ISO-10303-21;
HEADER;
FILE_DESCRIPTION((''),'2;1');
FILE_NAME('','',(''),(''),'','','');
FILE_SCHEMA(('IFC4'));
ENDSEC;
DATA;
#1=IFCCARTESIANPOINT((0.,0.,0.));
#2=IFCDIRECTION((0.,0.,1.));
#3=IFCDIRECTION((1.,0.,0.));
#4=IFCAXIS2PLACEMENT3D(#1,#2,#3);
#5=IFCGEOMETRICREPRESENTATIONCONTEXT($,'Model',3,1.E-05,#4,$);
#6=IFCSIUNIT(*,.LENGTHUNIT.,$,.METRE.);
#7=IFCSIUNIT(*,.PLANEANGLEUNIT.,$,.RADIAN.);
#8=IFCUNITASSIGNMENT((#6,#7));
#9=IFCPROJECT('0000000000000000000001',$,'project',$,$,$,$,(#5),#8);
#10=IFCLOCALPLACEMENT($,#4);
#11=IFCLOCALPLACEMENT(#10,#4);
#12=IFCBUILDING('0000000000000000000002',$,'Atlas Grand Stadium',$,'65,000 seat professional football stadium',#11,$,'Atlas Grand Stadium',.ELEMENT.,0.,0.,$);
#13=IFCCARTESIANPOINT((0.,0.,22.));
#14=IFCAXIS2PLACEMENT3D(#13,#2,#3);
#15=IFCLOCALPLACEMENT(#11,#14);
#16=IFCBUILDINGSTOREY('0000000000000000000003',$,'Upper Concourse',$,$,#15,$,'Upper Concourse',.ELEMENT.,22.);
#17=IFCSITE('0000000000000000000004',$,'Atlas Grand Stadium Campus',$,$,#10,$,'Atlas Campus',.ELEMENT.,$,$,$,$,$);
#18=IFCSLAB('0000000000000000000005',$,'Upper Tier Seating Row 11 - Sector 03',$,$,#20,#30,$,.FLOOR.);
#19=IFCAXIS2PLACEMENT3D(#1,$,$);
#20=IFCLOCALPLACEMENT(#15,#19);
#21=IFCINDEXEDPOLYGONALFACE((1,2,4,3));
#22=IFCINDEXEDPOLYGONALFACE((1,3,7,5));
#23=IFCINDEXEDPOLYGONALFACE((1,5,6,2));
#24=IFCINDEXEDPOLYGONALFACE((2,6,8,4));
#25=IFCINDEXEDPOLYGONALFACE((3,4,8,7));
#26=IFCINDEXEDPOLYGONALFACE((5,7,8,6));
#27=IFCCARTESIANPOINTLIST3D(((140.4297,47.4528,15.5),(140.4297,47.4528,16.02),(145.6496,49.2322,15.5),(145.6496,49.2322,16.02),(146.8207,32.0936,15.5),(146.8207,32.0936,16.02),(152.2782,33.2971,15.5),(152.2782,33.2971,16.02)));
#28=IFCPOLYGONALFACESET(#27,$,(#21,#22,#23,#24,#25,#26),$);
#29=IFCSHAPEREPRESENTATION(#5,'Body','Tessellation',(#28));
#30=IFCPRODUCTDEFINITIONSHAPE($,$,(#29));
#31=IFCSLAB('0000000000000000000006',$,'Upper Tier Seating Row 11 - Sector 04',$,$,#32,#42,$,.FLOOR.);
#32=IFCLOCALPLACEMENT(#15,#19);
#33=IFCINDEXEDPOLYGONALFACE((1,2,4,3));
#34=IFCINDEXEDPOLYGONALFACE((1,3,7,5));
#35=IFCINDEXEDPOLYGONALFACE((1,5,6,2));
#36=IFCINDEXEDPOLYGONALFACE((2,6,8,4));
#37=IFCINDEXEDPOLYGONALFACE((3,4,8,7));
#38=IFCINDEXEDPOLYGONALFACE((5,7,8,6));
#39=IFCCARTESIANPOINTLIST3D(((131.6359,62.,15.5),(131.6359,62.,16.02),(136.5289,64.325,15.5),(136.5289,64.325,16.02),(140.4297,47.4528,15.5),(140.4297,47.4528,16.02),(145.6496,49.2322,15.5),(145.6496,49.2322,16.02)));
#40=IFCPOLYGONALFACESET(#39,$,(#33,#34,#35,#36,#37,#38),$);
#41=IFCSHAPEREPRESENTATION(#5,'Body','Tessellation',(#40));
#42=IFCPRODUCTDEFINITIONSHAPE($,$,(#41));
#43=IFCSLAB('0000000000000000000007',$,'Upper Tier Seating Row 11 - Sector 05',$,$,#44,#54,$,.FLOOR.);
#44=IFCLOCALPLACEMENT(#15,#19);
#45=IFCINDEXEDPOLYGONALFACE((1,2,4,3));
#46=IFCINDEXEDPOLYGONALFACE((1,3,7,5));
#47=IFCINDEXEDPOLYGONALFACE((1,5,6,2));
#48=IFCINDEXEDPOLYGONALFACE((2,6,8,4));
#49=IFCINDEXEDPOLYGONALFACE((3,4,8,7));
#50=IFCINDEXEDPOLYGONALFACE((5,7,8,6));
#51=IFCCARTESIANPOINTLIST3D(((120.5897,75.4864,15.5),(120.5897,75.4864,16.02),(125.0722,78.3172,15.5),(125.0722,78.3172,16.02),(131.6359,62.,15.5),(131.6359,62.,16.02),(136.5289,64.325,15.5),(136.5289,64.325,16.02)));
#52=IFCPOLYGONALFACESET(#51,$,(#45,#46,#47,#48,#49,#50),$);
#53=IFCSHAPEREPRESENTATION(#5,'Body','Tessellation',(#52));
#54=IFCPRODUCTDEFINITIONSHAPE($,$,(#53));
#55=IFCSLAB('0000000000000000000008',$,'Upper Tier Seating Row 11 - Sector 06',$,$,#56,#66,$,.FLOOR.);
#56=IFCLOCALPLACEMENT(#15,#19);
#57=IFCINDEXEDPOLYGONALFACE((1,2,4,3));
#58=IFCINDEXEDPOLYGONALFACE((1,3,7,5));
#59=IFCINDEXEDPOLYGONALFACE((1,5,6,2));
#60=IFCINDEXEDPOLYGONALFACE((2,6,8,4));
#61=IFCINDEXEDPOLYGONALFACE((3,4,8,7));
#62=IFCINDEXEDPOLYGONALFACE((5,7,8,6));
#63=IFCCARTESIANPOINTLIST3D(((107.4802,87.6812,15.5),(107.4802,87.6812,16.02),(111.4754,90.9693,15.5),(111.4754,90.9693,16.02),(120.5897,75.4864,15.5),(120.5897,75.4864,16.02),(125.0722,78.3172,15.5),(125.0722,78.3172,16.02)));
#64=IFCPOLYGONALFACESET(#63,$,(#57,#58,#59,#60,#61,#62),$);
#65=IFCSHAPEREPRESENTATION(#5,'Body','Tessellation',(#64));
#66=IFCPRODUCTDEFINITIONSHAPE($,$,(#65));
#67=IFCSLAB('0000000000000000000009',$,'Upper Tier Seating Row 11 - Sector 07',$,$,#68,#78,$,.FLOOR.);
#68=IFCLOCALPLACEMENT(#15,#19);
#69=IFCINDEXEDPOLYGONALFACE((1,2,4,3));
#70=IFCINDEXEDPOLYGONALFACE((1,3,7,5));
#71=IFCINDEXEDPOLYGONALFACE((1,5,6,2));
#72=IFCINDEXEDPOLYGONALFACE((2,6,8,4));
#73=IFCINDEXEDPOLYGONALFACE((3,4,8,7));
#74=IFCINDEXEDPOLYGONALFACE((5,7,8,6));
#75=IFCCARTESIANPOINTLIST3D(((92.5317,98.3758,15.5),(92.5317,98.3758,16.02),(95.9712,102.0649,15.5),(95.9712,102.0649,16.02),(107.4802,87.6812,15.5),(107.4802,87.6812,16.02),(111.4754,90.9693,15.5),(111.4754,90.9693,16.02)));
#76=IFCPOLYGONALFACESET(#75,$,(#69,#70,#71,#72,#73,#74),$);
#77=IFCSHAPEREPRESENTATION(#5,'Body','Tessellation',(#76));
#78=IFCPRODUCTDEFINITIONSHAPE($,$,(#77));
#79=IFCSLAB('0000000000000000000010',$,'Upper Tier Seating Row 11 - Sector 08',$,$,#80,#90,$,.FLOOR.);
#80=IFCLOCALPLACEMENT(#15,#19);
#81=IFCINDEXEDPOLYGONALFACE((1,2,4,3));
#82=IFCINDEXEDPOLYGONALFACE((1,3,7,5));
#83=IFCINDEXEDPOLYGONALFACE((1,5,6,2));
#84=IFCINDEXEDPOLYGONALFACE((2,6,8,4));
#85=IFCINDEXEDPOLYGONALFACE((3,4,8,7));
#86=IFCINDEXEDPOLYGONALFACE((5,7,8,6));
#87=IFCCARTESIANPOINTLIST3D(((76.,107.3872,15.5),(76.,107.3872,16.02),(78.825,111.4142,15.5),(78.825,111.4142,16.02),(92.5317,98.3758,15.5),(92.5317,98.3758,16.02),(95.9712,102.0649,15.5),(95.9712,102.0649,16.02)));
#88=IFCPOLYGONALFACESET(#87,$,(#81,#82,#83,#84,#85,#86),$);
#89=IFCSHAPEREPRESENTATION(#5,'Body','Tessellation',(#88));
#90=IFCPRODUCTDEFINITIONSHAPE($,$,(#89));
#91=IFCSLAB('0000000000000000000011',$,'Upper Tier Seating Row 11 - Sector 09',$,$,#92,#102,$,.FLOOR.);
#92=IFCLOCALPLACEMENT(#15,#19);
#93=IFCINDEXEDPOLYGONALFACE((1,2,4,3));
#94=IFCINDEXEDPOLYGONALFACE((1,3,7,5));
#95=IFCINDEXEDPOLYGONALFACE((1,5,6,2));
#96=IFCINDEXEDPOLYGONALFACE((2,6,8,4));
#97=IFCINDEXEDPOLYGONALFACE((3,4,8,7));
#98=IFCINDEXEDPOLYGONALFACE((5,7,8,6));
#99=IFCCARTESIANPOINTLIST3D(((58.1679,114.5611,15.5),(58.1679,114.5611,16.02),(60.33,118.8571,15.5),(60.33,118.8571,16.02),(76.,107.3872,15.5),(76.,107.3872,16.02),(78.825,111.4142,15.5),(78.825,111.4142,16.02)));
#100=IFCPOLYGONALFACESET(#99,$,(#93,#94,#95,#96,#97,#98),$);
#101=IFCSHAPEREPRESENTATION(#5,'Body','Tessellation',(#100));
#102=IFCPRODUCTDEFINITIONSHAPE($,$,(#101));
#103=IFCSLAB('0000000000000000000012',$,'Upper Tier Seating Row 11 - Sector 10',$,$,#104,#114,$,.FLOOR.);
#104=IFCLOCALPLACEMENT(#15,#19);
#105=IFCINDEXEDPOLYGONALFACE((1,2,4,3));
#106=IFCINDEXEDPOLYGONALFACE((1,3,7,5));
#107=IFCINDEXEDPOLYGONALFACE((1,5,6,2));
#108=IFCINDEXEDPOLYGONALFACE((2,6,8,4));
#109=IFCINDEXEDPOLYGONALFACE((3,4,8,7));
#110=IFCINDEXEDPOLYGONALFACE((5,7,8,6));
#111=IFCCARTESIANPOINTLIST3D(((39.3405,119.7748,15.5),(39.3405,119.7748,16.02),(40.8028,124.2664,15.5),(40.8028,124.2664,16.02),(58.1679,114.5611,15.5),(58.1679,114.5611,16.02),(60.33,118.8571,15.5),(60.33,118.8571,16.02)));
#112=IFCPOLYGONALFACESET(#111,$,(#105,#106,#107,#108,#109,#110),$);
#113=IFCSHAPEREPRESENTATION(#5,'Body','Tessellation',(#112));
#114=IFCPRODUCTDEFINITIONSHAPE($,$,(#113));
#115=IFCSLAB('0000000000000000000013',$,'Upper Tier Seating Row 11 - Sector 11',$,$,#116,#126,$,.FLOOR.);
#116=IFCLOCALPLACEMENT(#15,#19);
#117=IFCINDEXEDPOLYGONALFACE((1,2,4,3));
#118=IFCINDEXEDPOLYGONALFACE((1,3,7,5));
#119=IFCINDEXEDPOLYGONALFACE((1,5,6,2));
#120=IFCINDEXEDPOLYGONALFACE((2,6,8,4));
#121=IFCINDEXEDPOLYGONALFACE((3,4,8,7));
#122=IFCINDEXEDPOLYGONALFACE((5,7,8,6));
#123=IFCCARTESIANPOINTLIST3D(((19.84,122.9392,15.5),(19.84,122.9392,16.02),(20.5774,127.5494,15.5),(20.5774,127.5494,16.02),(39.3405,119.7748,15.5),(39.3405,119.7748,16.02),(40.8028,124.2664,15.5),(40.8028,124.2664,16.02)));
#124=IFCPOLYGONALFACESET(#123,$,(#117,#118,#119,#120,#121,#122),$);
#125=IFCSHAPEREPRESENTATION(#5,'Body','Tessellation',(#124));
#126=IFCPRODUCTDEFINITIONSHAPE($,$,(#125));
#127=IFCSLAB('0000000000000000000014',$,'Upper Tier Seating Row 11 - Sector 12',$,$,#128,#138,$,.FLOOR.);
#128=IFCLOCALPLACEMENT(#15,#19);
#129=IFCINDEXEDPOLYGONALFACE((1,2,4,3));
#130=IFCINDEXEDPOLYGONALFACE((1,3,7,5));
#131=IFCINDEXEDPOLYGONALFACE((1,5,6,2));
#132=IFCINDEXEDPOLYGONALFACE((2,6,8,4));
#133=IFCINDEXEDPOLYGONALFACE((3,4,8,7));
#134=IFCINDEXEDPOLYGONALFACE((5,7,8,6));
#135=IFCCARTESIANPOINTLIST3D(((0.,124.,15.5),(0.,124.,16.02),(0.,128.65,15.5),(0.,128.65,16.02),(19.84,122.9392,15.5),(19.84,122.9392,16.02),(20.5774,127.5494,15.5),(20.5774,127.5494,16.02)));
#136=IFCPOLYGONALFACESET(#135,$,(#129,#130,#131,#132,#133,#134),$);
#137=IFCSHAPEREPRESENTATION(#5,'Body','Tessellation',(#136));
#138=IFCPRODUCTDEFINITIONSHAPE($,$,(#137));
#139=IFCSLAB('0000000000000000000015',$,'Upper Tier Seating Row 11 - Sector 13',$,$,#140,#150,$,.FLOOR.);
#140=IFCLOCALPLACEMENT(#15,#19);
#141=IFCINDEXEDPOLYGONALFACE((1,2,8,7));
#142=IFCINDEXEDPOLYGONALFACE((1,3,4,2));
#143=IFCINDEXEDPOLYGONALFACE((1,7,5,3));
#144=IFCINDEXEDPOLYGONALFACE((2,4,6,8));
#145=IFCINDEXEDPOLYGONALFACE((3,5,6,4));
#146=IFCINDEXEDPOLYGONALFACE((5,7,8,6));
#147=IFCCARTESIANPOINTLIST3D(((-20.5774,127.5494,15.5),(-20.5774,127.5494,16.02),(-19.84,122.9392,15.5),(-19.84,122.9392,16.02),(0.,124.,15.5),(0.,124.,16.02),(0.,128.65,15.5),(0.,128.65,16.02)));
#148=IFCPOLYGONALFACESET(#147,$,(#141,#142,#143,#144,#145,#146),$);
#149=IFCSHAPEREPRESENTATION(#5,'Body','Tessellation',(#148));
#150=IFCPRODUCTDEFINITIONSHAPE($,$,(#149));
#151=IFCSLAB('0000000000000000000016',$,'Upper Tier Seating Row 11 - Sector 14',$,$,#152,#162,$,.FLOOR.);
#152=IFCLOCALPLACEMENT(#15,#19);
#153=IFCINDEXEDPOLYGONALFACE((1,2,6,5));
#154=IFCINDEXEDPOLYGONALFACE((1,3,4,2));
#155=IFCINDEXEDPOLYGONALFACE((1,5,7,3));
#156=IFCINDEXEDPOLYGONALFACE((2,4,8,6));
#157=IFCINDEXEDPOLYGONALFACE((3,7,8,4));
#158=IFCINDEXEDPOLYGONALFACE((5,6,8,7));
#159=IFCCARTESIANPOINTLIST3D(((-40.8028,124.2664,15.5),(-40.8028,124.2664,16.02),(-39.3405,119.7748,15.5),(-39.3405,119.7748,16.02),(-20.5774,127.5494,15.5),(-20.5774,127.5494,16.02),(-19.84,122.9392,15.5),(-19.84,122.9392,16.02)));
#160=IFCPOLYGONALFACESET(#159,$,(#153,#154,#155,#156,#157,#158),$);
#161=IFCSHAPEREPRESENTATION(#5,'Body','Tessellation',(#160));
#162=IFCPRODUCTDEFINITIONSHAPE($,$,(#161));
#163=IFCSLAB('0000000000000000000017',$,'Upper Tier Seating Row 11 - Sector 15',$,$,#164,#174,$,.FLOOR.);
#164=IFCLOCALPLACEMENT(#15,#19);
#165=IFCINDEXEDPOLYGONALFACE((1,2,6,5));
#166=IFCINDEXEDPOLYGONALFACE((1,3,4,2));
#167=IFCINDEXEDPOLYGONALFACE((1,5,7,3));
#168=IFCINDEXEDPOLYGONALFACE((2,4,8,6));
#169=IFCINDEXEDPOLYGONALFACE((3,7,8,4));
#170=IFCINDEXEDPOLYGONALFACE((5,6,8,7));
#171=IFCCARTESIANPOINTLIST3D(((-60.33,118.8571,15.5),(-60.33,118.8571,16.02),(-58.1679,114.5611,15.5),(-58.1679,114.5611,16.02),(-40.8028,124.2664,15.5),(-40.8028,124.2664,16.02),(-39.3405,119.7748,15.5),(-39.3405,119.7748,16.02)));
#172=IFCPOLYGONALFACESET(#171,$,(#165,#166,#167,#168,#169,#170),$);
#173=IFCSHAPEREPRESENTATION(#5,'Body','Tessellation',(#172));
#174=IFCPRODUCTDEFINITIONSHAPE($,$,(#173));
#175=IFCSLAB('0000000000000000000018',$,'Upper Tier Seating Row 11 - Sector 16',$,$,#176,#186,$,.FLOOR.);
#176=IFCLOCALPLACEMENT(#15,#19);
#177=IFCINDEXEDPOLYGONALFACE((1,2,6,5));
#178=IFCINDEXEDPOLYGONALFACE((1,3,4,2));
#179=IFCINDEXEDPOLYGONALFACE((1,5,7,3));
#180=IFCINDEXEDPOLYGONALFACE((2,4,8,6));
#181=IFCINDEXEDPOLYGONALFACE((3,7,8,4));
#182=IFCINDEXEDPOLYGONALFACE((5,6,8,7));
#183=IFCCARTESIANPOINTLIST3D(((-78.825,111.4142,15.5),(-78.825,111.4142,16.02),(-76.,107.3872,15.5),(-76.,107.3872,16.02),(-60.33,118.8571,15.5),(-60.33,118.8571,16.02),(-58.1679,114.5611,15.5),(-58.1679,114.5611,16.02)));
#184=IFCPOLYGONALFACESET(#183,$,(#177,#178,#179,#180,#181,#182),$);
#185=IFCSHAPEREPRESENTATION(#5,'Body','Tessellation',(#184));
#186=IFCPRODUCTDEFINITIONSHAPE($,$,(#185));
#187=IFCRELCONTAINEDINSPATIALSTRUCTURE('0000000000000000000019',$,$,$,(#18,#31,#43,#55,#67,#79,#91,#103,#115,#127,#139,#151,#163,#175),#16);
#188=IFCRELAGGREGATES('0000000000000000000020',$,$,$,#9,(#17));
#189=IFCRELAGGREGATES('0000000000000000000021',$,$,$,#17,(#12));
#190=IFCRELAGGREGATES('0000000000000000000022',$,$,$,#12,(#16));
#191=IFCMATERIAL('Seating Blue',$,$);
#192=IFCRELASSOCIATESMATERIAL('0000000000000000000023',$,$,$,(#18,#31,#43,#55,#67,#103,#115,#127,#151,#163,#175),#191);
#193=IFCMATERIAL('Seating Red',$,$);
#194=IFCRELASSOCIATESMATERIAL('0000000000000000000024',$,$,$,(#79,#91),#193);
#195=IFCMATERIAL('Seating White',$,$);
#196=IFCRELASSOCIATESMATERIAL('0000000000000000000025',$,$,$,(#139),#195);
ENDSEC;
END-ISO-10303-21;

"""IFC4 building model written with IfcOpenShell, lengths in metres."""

from ifc_helpers import new_model, si_unit, frame, origin_with_axes, place, context, project, spatial, polyline, outline, extrude, material, element, save


model = new_model("IFC4")

# Units and contexts
model_context = context("Model", 3, precision=1e-05, world=origin_with_axes())
ifc_project = project(units=[si_unit("LENGTHUNIT", "METRE"), si_unit("PLANEANGLEUNIT", "RADIAN")], contexts=[model_context])

# Site, building, storey
site_placement = place(None, origin_with_axes())
site = spatial("IfcSite", under=ifc_project, at=site_placement, Name="Atlas Grand Stadium Campus", LongName="Atlas Campus", CompositionType="ELEMENT")
building_placement = place(site_placement, origin_with_axes())
building = spatial("IfcBuilding", under=site, at=building_placement, Name="Atlas Grand Stadium", ObjectType="65,000 seat professional football stadium", LongName="Atlas Grand Stadium", CompositionType="ELEMENT", ElevationOfRefHeight=0.0, ElevationOfTerrain=0.0)
storey_placement = place(building_placement, frame((0.0, 0.0, 22.0), z_axis=(0.0, 0.0, 1.0), x_axis=(1.0, 0.0, 0.0)))
storey = spatial("IfcBuildingStorey", under=building, at=storey_placement, Name="Upper Concourse", LongName="Upper Concourse", CompositionType="ELEMENT", Elevation=22.0)

# Slabs
ifc_material_1 = material(Name="Seating Blue")
slab_1_placement = place(storey_placement, frame((0.0, 0.0, 15.5), z_axis=(0.0, 0.0, 1.0), x_axis=(1.0, 0.0, 0.0)))
element("IfcSlab", 1, at=slab_1_placement, inside=storey, material=ifc_material_1, Name="Upper Tier Seating Row 11 - Sector 03", PredefinedType="FLOOR", context=model_context, shape_type="SweptSolid", body=[
    extrude(outline(polyline([(152.2782, 33.2971), (145.6496, 49.2322), (140.4297, 47.4528), (146.8207, 32.0936), (152.2782, 33.2971)])), origin_with_axes(), (0.0, 0.0, 1.0), 0.52),
])
slab_2_placement = place(storey_placement, frame((0.0, 0.0, 15.5), z_axis=(0.0, 0.0, 1.0), x_axis=(1.0, 0.0, 0.0)))
element("IfcSlab", 2, at=slab_2_placement, inside=storey, material=ifc_material_1, Name="Upper Tier Seating Row 11 - Sector 04", PredefinedType="FLOOR", context=model_context, shape_type="SweptSolid", body=[
    extrude(outline(polyline([(145.6496, 49.2322), (136.5289, 64.325), (131.6359, 62.0), (140.4297, 47.4528), (145.6496, 49.2322)])), origin_with_axes(), (0.0, 0.0, 1.0), 0.52),
])
slab_3_placement = place(storey_placement, frame((0.0, 0.0, 15.5), z_axis=(0.0, 0.0, 1.0), x_axis=(1.0, 0.0, 0.0)))
element("IfcSlab", 3, at=slab_3_placement, inside=storey, material=ifc_material_1, Name="Upper Tier Seating Row 11 - Sector 05", PredefinedType="FLOOR", context=model_context, shape_type="SweptSolid", body=[
    extrude(outline(polyline([(136.5289, 64.325), (125.0721, 78.3172), (120.5897, 75.4864), (131.6359, 62.0), (136.5289, 64.325)])), origin_with_axes(), (0.0, 0.0, 1.0), 0.52),
])
slab_4_placement = place(storey_placement, frame((0.0, 0.0, 15.5), z_axis=(0.0, 0.0, 1.0), x_axis=(1.0, 0.0, 0.0)))
element("IfcSlab", 4, at=slab_4_placement, inside=storey, material=ifc_material_1, Name="Upper Tier Seating Row 11 - Sector 06", PredefinedType="FLOOR", context=model_context, shape_type="SweptSolid", body=[
    extrude(outline(polyline([(125.0721, 78.3172), (111.4754, 90.9693), (107.4802, 87.6812), (120.5897, 75.4864), (125.0721, 78.3172)])), origin_with_axes(), (0.0, 0.0, 1.0), 0.52),
])
slab_5_placement = place(storey_placement, frame((0.0, 0.0, 15.5), z_axis=(0.0, 0.0, 1.0), x_axis=(1.0, 0.0, 0.0)))
element("IfcSlab", 5, at=slab_5_placement, inside=storey, material=ifc_material_1, Name="Upper Tier Seating Row 11 - Sector 07", PredefinedType="FLOOR", context=model_context, shape_type="SweptSolid", body=[
    extrude(outline(polyline([(111.4754, 90.9693), (95.9712, 102.0649), (92.5317, 98.3758), (107.4802, 87.6812), (111.4754, 90.9693)])), origin_with_axes(), (0.0, 0.0, 1.0), 0.52),
])
ifc_material_2 = material(Name="Seating Red")
slab_6_placement = place(storey_placement, frame((0.0, 0.0, 15.5), z_axis=(0.0, 0.0, 1.0), x_axis=(1.0, 0.0, 0.0)))
element("IfcSlab", 6, at=slab_6_placement, inside=storey, material=ifc_material_2, Name="Upper Tier Seating Row 11 - Sector 08", PredefinedType="FLOOR", context=model_context, shape_type="SweptSolid", body=[
    extrude(outline(polyline([(95.9712, 102.0649), (78.825, 111.4142), (76.0, 107.3872), (92.5317, 98.3758), (95.9712, 102.0649)])), origin_with_axes(), (0.0, 0.0, 1.0), 0.52),
])
slab_7_placement = place(storey_placement, frame((0.0, 0.0, 15.5), z_axis=(0.0, 0.0, 1.0), x_axis=(1.0, 0.0, 0.0)))
element("IfcSlab", 7, at=slab_7_placement, inside=storey, material=ifc_material_2, Name="Upper Tier Seating Row 11 - Sector 09", PredefinedType="FLOOR", context=model_context, shape_type="SweptSolid", body=[
    extrude(outline(polyline([(78.825, 111.4142), (60.33, 118.8571), (58.1679, 114.5611), (76.0, 107.3872), (78.825, 111.4142)])), origin_with_axes(), (0.0, 0.0, 1.0), 0.52),
])
slab_8_placement = place(storey_placement, frame((0.0, 0.0, 15.5), z_axis=(0.0, 0.0, 1.0), x_axis=(1.0, 0.0, 0.0)))
element("IfcSlab", 8, at=slab_8_placement, inside=storey, material=ifc_material_1, Name="Upper Tier Seating Row 11 - Sector 10", PredefinedType="FLOOR", context=model_context, shape_type="SweptSolid", body=[
    extrude(outline(polyline([(60.33, 118.8571), (40.8028, 124.2664), (39.3405, 119.7748), (58.1679, 114.5611), (60.33, 118.8571)])), origin_with_axes(), (0.0, 0.0, 1.0), 0.52),
])
slab_9_placement = place(storey_placement, frame((0.0, 0.0, 15.5), z_axis=(0.0, 0.0, 1.0), x_axis=(1.0, 0.0, 0.0)))
element("IfcSlab", 9, at=slab_9_placement, inside=storey, material=ifc_material_1, Name="Upper Tier Seating Row 11 - Sector 11", PredefinedType="FLOOR", context=model_context, shape_type="SweptSolid", body=[
    extrude(outline(polyline([(40.8028, 124.2664), (20.5774, 127.5494), (19.84, 122.9392), (39.3405, 119.7748), (40.8028, 124.2664)])), origin_with_axes(), (0.0, 0.0, 1.0), 0.52),
])
slab_10_placement = place(storey_placement, frame((0.0, 0.0, 15.5), z_axis=(0.0, 0.0, 1.0), x_axis=(1.0, 0.0, 0.0)))
element("IfcSlab", 10, at=slab_10_placement, inside=storey, material=ifc_material_1, Name="Upper Tier Seating Row 11 - Sector 12", PredefinedType="FLOOR", context=model_context, shape_type="SweptSolid", body=[
    extrude(outline(polyline([(20.5774, 127.5494), (0.0, 128.65), (0.0, 124.0), (19.84, 122.9392), (20.5774, 127.5494)])), origin_with_axes(), (0.0, 0.0, 1.0), 0.52),
])
ifc_material_3 = material(Name="Seating White")
slab_11_placement = place(storey_placement, frame((0.0, 0.0, 15.5), z_axis=(0.0, 0.0, 1.0), x_axis=(1.0, 0.0, 0.0)))
element("IfcSlab", 11, at=slab_11_placement, inside=storey, material=ifc_material_3, Name="Upper Tier Seating Row 11 - Sector 13", PredefinedType="FLOOR", context=model_context, shape_type="SweptSolid", body=[
    extrude(outline(polyline([(0.0, 128.65), (-20.5774, 127.5494), (-19.84, 122.9392), (0.0, 124.0), (0.0, 128.65)])), origin_with_axes(), (0.0, 0.0, 1.0), 0.52),
])
slab_12_placement = place(storey_placement, frame((0.0, 0.0, 15.5), z_axis=(0.0, 0.0, 1.0), x_axis=(1.0, 0.0, 0.0)))
element("IfcSlab", 12, at=slab_12_placement, inside=storey, material=ifc_material_1, Name="Upper Tier Seating Row 11 - Sector 14", PredefinedType="FLOOR", context=model_context, shape_type="SweptSolid", body=[
    extrude(outline(polyline([(-20.5774, 127.5494), (-40.8028, 124.2664), (-39.3405, 119.7748), (-19.84, 122.9392), (-20.5774, 127.5494)])), origin_with_axes(), (0.0, 0.0, 1.0), 0.52),
])
slab_13_placement = place(storey_placement, frame((0.0, 0.0, 15.5), z_axis=(0.0, 0.0, 1.0), x_axis=(1.0, 0.0, 0.0)))
element("IfcSlab", 13, at=slab_13_placement, inside=storey, material=ifc_material_1, Name="Upper Tier Seating Row 11 - Sector 15", PredefinedType="FLOOR", context=model_context, shape_type="SweptSolid", body=[
    extrude(outline(polyline([(-40.8028, 124.2664), (-60.33, 118.8571), (-58.1679, 114.5611), (-39.3405, 119.7748), (-40.8028, 124.2664)])), origin_with_axes(), (0.0, 0.0, 1.0), 0.52),
])
slab_14_placement = place(storey_placement, frame((0.0, 0.0, 15.5), z_axis=(0.0, 0.0, 1.0), x_axis=(1.0, 0.0, 0.0)))
element("IfcSlab", 14, at=slab_14_placement, inside=storey, material=ifc_material_1, Name="Upper Tier Seating Row 11 - Sector 16", PredefinedType="FLOOR", context=model_context, shape_type="SweptSolid", body=[
    extrude(outline(polyline([(-60.33, 118.8571), (-78.825, 111.4142), (-76.0, 107.3872), (-58.1679, 114.5611), (-60.33, 118.8571)])), origin_with_axes(), (0.0, 0.0, 1.0), 0.52),
])

save(model, "model.ifc")
